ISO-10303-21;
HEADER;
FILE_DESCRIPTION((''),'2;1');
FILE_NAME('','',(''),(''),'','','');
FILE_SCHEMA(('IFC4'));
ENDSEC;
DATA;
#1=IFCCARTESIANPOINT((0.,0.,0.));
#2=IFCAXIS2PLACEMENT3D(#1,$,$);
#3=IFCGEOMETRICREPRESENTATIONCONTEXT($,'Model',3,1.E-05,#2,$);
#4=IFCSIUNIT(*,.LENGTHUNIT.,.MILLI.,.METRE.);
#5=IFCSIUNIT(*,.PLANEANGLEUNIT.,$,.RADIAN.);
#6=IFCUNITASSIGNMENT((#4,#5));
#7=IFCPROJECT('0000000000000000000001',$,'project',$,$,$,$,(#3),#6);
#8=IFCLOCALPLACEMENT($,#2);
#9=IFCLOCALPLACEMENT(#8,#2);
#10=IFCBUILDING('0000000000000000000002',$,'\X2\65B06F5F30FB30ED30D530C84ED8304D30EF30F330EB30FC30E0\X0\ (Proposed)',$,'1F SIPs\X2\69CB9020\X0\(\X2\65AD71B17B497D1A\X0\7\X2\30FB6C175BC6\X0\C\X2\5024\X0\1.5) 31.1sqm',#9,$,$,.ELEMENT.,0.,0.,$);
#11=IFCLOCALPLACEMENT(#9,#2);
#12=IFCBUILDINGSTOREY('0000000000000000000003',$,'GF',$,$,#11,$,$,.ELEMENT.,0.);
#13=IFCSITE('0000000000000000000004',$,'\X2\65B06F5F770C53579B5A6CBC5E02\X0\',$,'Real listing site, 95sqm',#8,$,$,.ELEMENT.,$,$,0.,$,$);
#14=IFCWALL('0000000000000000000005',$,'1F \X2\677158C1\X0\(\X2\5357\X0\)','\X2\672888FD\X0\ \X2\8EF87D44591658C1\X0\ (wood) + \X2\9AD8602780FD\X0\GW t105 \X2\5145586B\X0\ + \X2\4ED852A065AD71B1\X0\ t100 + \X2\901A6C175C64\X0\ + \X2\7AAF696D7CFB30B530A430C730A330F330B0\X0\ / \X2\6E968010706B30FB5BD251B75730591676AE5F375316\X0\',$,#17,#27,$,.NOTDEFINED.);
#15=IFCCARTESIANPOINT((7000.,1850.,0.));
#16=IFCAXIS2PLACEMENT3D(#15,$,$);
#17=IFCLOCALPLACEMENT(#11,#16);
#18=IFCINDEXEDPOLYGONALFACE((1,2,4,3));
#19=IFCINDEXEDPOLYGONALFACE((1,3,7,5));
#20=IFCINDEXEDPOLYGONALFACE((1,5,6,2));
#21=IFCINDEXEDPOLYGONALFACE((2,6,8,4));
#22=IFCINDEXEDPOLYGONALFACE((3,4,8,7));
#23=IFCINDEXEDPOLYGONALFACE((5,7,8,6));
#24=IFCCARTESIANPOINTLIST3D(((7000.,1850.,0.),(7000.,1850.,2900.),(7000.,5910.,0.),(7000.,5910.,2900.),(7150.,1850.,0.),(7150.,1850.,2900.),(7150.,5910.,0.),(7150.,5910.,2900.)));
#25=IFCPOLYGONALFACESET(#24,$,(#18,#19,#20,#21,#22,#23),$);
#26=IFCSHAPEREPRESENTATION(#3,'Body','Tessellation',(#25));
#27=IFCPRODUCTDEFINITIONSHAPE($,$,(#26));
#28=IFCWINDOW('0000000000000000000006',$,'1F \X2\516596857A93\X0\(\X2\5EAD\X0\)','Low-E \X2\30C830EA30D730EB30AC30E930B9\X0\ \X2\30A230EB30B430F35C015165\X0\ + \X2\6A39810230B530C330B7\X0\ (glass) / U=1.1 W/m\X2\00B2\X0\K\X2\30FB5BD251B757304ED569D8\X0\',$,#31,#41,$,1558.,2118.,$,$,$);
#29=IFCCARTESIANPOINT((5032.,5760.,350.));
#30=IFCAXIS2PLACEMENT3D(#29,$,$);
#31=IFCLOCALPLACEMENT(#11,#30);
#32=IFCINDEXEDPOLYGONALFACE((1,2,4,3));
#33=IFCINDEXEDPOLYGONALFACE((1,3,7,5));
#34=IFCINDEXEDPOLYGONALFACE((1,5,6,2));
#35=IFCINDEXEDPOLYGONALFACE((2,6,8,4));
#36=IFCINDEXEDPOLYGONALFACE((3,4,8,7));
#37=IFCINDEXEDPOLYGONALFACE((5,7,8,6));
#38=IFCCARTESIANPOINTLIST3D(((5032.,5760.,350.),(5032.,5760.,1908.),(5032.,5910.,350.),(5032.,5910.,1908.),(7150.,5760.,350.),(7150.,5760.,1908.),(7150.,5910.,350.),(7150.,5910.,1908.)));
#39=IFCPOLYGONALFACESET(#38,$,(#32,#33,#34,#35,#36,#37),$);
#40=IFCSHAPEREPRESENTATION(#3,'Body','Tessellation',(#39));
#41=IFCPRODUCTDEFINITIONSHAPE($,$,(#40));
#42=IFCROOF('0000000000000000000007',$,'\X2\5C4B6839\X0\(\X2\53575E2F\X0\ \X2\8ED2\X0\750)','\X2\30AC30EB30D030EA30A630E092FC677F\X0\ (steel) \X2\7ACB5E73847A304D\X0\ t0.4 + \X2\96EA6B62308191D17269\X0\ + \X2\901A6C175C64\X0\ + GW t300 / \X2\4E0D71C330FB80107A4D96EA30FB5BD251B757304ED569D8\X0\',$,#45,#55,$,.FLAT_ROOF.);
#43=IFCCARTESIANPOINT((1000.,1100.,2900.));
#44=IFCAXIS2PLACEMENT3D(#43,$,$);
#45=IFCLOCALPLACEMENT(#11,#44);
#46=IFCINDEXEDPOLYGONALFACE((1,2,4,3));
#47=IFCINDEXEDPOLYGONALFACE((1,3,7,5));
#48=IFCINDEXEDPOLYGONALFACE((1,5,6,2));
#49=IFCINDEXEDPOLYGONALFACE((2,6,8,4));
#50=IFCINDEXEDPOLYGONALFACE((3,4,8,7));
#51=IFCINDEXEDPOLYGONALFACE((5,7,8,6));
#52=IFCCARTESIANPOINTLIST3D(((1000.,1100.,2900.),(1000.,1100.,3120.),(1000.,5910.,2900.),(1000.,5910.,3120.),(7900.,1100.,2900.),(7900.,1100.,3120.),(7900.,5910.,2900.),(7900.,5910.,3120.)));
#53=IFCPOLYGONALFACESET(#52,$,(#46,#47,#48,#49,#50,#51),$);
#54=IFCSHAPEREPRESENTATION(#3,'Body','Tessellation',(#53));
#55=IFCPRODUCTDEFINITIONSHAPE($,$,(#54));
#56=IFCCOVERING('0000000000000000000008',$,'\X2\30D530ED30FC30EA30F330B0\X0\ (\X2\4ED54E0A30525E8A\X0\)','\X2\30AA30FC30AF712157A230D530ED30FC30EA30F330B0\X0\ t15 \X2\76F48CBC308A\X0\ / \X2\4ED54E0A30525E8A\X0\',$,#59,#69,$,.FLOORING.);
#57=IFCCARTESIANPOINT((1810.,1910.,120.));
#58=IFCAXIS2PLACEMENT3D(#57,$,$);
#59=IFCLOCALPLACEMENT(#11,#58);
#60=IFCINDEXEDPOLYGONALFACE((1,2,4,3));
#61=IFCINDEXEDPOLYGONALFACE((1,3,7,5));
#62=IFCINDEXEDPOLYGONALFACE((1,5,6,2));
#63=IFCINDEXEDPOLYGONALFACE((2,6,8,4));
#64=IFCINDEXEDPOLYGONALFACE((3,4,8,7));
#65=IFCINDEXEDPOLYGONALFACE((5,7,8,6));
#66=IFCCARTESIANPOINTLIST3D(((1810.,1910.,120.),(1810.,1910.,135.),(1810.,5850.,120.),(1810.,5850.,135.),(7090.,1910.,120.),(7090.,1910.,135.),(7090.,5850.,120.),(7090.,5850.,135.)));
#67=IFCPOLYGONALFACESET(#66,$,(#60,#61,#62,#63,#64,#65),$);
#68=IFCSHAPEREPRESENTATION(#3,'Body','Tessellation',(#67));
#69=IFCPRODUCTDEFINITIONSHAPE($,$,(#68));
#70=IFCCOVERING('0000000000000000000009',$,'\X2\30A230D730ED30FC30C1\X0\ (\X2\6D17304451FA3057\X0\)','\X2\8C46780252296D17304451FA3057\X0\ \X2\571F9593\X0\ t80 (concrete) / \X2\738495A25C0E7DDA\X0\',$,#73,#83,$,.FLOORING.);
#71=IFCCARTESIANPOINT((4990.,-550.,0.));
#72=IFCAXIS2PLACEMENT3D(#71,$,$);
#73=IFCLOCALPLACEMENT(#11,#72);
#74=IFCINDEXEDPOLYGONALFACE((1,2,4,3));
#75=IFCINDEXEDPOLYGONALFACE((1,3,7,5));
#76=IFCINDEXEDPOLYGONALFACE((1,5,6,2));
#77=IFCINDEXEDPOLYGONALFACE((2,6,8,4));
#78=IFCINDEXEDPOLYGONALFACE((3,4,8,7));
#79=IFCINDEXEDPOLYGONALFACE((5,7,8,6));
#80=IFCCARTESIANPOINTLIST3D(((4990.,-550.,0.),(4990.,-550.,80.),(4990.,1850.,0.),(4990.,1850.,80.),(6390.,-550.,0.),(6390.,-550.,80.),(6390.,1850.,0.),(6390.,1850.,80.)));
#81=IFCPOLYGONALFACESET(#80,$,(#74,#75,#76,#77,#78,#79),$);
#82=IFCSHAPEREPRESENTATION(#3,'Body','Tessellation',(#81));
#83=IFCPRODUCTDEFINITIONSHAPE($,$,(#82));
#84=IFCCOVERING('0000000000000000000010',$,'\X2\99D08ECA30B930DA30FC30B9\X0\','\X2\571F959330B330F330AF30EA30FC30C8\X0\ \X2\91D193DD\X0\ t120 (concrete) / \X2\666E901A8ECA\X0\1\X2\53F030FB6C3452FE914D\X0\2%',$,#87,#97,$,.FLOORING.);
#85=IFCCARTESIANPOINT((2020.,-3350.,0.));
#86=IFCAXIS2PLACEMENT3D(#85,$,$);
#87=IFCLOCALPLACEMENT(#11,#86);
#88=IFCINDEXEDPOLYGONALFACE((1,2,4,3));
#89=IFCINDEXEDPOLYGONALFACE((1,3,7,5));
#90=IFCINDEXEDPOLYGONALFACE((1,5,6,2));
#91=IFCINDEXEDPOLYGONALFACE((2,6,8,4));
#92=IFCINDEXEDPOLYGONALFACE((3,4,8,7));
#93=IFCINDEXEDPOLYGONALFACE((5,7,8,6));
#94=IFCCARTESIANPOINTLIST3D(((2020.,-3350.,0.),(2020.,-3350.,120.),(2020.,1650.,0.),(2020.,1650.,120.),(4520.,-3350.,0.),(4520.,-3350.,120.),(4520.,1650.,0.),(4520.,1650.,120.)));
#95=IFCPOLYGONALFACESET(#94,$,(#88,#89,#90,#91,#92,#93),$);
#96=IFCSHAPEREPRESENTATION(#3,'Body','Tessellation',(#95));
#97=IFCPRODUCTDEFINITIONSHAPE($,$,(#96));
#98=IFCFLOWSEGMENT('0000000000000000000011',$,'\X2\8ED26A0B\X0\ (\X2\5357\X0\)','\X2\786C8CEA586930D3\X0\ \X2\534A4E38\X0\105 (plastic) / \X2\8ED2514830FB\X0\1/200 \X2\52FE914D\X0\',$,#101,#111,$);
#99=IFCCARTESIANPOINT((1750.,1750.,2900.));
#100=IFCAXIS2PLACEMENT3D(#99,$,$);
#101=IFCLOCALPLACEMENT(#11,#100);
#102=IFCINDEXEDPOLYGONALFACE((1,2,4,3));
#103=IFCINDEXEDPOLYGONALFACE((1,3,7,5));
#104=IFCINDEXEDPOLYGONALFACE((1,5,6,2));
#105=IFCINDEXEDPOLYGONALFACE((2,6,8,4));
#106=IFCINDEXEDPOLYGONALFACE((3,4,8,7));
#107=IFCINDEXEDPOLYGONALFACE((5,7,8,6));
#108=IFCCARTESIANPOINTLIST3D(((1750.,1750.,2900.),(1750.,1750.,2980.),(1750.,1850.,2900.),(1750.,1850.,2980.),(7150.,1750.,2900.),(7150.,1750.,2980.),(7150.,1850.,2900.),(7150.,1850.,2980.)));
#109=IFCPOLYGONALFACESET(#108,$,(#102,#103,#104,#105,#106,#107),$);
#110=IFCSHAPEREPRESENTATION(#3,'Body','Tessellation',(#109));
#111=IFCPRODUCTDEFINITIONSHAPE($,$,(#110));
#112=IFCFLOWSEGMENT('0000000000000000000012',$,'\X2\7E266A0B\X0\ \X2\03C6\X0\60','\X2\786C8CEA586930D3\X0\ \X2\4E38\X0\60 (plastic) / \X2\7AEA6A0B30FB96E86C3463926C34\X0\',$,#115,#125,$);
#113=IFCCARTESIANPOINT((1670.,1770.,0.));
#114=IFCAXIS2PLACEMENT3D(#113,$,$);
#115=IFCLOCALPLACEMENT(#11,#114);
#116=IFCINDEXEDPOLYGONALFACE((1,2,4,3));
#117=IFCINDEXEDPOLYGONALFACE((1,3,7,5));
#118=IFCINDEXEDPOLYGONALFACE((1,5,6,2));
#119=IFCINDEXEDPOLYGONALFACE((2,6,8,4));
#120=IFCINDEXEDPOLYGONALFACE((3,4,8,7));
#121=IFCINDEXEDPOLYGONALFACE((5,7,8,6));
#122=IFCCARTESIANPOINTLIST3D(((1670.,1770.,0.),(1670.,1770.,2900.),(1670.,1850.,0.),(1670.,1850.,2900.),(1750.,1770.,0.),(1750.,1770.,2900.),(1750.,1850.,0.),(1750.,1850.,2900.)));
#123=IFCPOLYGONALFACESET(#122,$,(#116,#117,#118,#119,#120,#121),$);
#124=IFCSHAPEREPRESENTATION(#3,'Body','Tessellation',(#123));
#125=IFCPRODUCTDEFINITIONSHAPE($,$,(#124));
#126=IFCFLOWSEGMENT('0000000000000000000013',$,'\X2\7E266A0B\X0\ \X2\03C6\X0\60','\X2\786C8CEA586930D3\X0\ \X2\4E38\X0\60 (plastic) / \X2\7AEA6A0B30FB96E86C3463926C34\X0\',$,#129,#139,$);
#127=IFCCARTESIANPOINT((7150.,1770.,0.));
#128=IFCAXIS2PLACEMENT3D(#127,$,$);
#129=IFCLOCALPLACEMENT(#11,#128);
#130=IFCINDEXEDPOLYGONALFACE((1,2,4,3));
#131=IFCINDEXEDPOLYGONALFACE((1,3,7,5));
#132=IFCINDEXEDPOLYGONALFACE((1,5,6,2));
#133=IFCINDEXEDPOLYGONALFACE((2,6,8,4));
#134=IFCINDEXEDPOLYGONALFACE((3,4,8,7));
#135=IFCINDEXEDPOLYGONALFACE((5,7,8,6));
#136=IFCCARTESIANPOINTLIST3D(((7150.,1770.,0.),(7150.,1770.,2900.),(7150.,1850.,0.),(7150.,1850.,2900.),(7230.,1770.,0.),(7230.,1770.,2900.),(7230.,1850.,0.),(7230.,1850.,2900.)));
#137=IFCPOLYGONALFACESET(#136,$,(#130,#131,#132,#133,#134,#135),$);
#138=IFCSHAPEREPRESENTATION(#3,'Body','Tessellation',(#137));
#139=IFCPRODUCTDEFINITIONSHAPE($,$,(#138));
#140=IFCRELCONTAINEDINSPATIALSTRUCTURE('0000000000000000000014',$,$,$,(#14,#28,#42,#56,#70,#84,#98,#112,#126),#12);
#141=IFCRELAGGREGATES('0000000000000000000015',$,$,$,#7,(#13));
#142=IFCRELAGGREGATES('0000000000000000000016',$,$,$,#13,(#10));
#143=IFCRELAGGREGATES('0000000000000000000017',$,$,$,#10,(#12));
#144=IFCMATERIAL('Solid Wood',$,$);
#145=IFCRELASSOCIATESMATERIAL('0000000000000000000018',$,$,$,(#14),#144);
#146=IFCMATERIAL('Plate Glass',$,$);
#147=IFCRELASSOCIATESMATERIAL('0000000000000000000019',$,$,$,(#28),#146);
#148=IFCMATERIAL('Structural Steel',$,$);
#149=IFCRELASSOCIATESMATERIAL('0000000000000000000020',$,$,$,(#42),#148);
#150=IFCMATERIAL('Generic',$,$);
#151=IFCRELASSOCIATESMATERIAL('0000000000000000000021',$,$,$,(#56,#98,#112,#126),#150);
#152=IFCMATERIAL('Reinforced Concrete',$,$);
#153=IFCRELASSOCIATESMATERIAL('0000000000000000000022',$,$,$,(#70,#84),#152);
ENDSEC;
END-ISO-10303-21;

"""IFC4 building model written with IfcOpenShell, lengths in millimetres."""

from ifc_helpers import new_model, si_unit, frame, frame_2d, origin, place, context, project, spatial, rectangle, extrude, material, element, fill, save


model = new_model("IFC4")

# Units and contexts
model_context = context("Model", 3, precision=1e-05, world=origin())
ifc_project = project(units=[si_unit("LENGTHUNIT", "METRE", prefix="MILLI"), si_unit("PLANEANGLEUNIT", "RADIAN")], contexts=[model_context])

# Site, building, storey
site_placement = place(None, origin())
site = spatial("IfcSite", under=ifc_project, at=site_placement, Name="新潟県南魚沼市", ObjectType="Real listing site, 95sqm", CompositionType="ELEMENT", RefElevation=0.0)
building_placement = place(site_placement, origin())
building = spatial("IfcBuilding", under=site, at=building_placement, Name="新潟・ロフト付きワンルーム (Proposed)", ObjectType="1F SIPs構造(断熱等級7・気密C値1.5) 31.1sqm", CompositionType="ELEMENT", ElevationOfRefHeight=0.0, ElevationOfTerrain=0.0)
storey_placement = place(building_placement, origin())
storey = spatial("IfcBuildingStorey", under=building, at=storey_placement, Name="GF", CompositionType="ELEMENT", Elevation=0.0)

# Shared definitions
ifc_material_1 = material(Name="Solid Wood")

# Shared definitions
ifc_material_2 = material(Name="Reinforced Concrete")

# Shared definitions
ifc_material_3 = material(Name="Plate Glass")

# Wall, opening, window
wall_1_placement = place(storey_placement, frame((7000.0, 1850.0, 0.0)))
wall_1 = element("IfcWall", 1, at=wall_1_placement, inside=storey, material=ifc_material_1, Name="1F 東壁(南)", Description="木製 軸組外壁 (wood) + 高性能GW t105 充填 + 付加断熱 t100 + 通気層 + 窯業系サイディング / 準耐火・寒冷地外皮強化", PredefinedType="NOTDEFINED", context=model_context, shape_type="SweptSolid", body=[
    extrude(rectangle(XDim=150.0, YDim=4060.0, at=frame_2d((75.0, 2030.0))), frame((7000.0, 1850.0, 0.0)), (0.0, 0.0, 1.0), 2900.0),
])
opening_1_placement = place(storey_placement, frame((5032.0, 5760.0, 350.0)))
opening_1 = element("IfcOpeningElement", 2, at=opening_1_placement, cuts=wall_1, PredefinedType="NOTDEFINED", context=model_context, shape_type="SweptSolid", body=[
    extrude(rectangle(XDim=2118.0, YDim=150.0, at=frame_2d((1059.0, 75.0))), frame((5032.0, 5760.0, 350.0)), (0.0, 0.0, 1.0), 1558.0),
])
window_1_placement = place(storey_placement, frame((5032.0, 5760.0, 350.0)))
window_1 = element("IfcWindow", 3, at=window_1_placement, inside=storey, material=ifc_material_3, Name="1F 入隅窓(庭)", Description="Low-E トリプルガラス アルゴン封入 + 樹脂サッシ (glass) / U=1.1 W/m²K・寒冷地仕様", OverallHeight=1558.0, OverallWidth=2118.0, context=model_context, shape_type="SweptSolid", body=[
    extrude(rectangle(XDim=2118.0, YDim=150.0, at=frame_2d((1059.0, 75.0))), frame((5032.0, 5760.0, 350.0)), (0.0, 0.0, 1.0), 1558.0),
])
fill(opening_1, window_1)

# Roof
ifc_material_4 = material(Name="Structural Steel")
roof_placement = place(storey_placement, frame((1000.0, 1100.0, 2900.0)))
element("IfcRoof", 4, at=roof_placement, inside=storey, material=ifc_material_4, Name="屋根(南帯 軒750)", Description="ガルバリウム鋼板 (steel) 立平葺き t0.4 + 雪止め金物 + 通気層 + GW t300 / 不燃・耐積雪・寒冷地仕様", PredefinedType="FLAT_ROOF", context=model_context, shape_type="SweptSolid", body=[
    extrude(rectangle(XDim=6900.0, YDim=4810.0, at=frame_2d((3450.0, 2405.0))), frame((1000.0, 1100.0, 2900.0)), (0.0, 0.0, 1.0), 220.0),
])

# Coverings
ifc_material_5 = material(Name="Generic")
covering_1_placement = place(storey_placement, frame((1810.0, 1910.0, 120.0)))
element("IfcCovering", 5, at=covering_1_placement, inside=storey, material=ifc_material_5, Name="フローリング (仕上げ床)", Description="オーク無垢フローリング t15 直貼り / 仕上げ床", PredefinedType="FLOORING", context=model_context, shape_type="SweptSolid", body=[
    extrude(rectangle(XDim=5280.0, YDim=3940.0, at=frame_2d((2640.0, 1970.0))), frame((1810.0, 1910.0, 120.0)), (0.0, 0.0, 1.0), 15.0),
])
covering_2_placement = place(storey_placement, frame((4990.0, -550.0, 0.0)))
element("IfcCovering", 6, at=covering_2_placement, inside=storey, material=ifc_material_2, Name="アプローチ (洗い出し)", Description="豆砂利洗い出し 土間 t80 (concrete) / 玄関導線", PredefinedType="FLOORING", context=model_context, shape_type="SweptSolid", body=[
    extrude(rectangle(XDim=1400.0, YDim=2400.0, at=frame_2d((700.0, 1200.0))), frame((4990.0, -550.0, 0.0)), (0.0, 0.0, 1.0), 80.0),
])
covering_3_placement = place(storey_placement, frame((2020.0, -3350.0, 0.0)))
element("IfcCovering", 7, at=covering_3_placement, inside=storey, material=ifc_material_2, Name="駐車スペース", Description="土間コンクリート 金鏝 t120 (concrete) / 普通車1台・水勾配2%", PredefinedType="FLOORING", context=model_context, shape_type="SweptSolid", body=[
    extrude(rectangle(XDim=2500.0, YDim=5000.0, at=frame_2d((1250.0, 2500.0))), frame((2020.0, -3350.0, 0.0)), (0.0, 0.0, 1.0), 120.0),
])

# Flow segments
flow_segment_1_placement = place(storey_placement, frame((1750.0, 1750.0, 2900.0)))
element("IfcFlowSegment", 8, at=flow_segment_1_placement, inside=storey, material=ifc_material_5, Name="軒樋 (南)", Description="硬質塩ビ 半丸105 (plastic) / 軒先・1/200 勾配", context=model_context, shape_type="SweptSolid", body=[
    extrude(rectangle(XDim=5400.0, YDim=100.0, at=frame_2d((2700.0, 50.0))), frame((1750.0, 1750.0, 2900.0)), (0.0, 0.0, 1.0), 80.0),
])
flow_segment_2_placement = place(storey_placement, frame((1670.0, 1770.0, 0.0)))
element("IfcFlowSegment", 9, at=flow_segment_2_placement, inside=storey, material=ifc_material_5, Name="縦樋 φ60", Description="硬質塩ビ 丸60 (plastic) / 竪樋・雨水排水", context=model_context, shape_type="SweptSolid", body=[
    extrude(rectangle(XDim=80.0, YDim=80.0, at=frame_2d((40.0, 40.0))), frame((1670.0, 1770.0, 0.0)), (0.0, 0.0, 1.0), 2900.0),
])
flow_segment_3_placement = place(storey_placement, frame((7150.0, 1770.0, 0.0)))
element("IfcFlowSegment", 10, at=flow_segment_3_placement, inside=storey, material=ifc_material_5, Name="縦樋 φ60", Description="硬質塩ビ 丸60 (plastic) / 竪樋・雨水排水", context=model_context, shape_type="SweptSolid", body=[
    extrude(rectangle(XDim=80.0, YDim=80.0, at=frame_2d((40.0, 40.0))), frame((7150.0, 1770.0, 0.0)), (0.0, 0.0, 1.0), 2900.0),
])

save(model, "model.ifc")
